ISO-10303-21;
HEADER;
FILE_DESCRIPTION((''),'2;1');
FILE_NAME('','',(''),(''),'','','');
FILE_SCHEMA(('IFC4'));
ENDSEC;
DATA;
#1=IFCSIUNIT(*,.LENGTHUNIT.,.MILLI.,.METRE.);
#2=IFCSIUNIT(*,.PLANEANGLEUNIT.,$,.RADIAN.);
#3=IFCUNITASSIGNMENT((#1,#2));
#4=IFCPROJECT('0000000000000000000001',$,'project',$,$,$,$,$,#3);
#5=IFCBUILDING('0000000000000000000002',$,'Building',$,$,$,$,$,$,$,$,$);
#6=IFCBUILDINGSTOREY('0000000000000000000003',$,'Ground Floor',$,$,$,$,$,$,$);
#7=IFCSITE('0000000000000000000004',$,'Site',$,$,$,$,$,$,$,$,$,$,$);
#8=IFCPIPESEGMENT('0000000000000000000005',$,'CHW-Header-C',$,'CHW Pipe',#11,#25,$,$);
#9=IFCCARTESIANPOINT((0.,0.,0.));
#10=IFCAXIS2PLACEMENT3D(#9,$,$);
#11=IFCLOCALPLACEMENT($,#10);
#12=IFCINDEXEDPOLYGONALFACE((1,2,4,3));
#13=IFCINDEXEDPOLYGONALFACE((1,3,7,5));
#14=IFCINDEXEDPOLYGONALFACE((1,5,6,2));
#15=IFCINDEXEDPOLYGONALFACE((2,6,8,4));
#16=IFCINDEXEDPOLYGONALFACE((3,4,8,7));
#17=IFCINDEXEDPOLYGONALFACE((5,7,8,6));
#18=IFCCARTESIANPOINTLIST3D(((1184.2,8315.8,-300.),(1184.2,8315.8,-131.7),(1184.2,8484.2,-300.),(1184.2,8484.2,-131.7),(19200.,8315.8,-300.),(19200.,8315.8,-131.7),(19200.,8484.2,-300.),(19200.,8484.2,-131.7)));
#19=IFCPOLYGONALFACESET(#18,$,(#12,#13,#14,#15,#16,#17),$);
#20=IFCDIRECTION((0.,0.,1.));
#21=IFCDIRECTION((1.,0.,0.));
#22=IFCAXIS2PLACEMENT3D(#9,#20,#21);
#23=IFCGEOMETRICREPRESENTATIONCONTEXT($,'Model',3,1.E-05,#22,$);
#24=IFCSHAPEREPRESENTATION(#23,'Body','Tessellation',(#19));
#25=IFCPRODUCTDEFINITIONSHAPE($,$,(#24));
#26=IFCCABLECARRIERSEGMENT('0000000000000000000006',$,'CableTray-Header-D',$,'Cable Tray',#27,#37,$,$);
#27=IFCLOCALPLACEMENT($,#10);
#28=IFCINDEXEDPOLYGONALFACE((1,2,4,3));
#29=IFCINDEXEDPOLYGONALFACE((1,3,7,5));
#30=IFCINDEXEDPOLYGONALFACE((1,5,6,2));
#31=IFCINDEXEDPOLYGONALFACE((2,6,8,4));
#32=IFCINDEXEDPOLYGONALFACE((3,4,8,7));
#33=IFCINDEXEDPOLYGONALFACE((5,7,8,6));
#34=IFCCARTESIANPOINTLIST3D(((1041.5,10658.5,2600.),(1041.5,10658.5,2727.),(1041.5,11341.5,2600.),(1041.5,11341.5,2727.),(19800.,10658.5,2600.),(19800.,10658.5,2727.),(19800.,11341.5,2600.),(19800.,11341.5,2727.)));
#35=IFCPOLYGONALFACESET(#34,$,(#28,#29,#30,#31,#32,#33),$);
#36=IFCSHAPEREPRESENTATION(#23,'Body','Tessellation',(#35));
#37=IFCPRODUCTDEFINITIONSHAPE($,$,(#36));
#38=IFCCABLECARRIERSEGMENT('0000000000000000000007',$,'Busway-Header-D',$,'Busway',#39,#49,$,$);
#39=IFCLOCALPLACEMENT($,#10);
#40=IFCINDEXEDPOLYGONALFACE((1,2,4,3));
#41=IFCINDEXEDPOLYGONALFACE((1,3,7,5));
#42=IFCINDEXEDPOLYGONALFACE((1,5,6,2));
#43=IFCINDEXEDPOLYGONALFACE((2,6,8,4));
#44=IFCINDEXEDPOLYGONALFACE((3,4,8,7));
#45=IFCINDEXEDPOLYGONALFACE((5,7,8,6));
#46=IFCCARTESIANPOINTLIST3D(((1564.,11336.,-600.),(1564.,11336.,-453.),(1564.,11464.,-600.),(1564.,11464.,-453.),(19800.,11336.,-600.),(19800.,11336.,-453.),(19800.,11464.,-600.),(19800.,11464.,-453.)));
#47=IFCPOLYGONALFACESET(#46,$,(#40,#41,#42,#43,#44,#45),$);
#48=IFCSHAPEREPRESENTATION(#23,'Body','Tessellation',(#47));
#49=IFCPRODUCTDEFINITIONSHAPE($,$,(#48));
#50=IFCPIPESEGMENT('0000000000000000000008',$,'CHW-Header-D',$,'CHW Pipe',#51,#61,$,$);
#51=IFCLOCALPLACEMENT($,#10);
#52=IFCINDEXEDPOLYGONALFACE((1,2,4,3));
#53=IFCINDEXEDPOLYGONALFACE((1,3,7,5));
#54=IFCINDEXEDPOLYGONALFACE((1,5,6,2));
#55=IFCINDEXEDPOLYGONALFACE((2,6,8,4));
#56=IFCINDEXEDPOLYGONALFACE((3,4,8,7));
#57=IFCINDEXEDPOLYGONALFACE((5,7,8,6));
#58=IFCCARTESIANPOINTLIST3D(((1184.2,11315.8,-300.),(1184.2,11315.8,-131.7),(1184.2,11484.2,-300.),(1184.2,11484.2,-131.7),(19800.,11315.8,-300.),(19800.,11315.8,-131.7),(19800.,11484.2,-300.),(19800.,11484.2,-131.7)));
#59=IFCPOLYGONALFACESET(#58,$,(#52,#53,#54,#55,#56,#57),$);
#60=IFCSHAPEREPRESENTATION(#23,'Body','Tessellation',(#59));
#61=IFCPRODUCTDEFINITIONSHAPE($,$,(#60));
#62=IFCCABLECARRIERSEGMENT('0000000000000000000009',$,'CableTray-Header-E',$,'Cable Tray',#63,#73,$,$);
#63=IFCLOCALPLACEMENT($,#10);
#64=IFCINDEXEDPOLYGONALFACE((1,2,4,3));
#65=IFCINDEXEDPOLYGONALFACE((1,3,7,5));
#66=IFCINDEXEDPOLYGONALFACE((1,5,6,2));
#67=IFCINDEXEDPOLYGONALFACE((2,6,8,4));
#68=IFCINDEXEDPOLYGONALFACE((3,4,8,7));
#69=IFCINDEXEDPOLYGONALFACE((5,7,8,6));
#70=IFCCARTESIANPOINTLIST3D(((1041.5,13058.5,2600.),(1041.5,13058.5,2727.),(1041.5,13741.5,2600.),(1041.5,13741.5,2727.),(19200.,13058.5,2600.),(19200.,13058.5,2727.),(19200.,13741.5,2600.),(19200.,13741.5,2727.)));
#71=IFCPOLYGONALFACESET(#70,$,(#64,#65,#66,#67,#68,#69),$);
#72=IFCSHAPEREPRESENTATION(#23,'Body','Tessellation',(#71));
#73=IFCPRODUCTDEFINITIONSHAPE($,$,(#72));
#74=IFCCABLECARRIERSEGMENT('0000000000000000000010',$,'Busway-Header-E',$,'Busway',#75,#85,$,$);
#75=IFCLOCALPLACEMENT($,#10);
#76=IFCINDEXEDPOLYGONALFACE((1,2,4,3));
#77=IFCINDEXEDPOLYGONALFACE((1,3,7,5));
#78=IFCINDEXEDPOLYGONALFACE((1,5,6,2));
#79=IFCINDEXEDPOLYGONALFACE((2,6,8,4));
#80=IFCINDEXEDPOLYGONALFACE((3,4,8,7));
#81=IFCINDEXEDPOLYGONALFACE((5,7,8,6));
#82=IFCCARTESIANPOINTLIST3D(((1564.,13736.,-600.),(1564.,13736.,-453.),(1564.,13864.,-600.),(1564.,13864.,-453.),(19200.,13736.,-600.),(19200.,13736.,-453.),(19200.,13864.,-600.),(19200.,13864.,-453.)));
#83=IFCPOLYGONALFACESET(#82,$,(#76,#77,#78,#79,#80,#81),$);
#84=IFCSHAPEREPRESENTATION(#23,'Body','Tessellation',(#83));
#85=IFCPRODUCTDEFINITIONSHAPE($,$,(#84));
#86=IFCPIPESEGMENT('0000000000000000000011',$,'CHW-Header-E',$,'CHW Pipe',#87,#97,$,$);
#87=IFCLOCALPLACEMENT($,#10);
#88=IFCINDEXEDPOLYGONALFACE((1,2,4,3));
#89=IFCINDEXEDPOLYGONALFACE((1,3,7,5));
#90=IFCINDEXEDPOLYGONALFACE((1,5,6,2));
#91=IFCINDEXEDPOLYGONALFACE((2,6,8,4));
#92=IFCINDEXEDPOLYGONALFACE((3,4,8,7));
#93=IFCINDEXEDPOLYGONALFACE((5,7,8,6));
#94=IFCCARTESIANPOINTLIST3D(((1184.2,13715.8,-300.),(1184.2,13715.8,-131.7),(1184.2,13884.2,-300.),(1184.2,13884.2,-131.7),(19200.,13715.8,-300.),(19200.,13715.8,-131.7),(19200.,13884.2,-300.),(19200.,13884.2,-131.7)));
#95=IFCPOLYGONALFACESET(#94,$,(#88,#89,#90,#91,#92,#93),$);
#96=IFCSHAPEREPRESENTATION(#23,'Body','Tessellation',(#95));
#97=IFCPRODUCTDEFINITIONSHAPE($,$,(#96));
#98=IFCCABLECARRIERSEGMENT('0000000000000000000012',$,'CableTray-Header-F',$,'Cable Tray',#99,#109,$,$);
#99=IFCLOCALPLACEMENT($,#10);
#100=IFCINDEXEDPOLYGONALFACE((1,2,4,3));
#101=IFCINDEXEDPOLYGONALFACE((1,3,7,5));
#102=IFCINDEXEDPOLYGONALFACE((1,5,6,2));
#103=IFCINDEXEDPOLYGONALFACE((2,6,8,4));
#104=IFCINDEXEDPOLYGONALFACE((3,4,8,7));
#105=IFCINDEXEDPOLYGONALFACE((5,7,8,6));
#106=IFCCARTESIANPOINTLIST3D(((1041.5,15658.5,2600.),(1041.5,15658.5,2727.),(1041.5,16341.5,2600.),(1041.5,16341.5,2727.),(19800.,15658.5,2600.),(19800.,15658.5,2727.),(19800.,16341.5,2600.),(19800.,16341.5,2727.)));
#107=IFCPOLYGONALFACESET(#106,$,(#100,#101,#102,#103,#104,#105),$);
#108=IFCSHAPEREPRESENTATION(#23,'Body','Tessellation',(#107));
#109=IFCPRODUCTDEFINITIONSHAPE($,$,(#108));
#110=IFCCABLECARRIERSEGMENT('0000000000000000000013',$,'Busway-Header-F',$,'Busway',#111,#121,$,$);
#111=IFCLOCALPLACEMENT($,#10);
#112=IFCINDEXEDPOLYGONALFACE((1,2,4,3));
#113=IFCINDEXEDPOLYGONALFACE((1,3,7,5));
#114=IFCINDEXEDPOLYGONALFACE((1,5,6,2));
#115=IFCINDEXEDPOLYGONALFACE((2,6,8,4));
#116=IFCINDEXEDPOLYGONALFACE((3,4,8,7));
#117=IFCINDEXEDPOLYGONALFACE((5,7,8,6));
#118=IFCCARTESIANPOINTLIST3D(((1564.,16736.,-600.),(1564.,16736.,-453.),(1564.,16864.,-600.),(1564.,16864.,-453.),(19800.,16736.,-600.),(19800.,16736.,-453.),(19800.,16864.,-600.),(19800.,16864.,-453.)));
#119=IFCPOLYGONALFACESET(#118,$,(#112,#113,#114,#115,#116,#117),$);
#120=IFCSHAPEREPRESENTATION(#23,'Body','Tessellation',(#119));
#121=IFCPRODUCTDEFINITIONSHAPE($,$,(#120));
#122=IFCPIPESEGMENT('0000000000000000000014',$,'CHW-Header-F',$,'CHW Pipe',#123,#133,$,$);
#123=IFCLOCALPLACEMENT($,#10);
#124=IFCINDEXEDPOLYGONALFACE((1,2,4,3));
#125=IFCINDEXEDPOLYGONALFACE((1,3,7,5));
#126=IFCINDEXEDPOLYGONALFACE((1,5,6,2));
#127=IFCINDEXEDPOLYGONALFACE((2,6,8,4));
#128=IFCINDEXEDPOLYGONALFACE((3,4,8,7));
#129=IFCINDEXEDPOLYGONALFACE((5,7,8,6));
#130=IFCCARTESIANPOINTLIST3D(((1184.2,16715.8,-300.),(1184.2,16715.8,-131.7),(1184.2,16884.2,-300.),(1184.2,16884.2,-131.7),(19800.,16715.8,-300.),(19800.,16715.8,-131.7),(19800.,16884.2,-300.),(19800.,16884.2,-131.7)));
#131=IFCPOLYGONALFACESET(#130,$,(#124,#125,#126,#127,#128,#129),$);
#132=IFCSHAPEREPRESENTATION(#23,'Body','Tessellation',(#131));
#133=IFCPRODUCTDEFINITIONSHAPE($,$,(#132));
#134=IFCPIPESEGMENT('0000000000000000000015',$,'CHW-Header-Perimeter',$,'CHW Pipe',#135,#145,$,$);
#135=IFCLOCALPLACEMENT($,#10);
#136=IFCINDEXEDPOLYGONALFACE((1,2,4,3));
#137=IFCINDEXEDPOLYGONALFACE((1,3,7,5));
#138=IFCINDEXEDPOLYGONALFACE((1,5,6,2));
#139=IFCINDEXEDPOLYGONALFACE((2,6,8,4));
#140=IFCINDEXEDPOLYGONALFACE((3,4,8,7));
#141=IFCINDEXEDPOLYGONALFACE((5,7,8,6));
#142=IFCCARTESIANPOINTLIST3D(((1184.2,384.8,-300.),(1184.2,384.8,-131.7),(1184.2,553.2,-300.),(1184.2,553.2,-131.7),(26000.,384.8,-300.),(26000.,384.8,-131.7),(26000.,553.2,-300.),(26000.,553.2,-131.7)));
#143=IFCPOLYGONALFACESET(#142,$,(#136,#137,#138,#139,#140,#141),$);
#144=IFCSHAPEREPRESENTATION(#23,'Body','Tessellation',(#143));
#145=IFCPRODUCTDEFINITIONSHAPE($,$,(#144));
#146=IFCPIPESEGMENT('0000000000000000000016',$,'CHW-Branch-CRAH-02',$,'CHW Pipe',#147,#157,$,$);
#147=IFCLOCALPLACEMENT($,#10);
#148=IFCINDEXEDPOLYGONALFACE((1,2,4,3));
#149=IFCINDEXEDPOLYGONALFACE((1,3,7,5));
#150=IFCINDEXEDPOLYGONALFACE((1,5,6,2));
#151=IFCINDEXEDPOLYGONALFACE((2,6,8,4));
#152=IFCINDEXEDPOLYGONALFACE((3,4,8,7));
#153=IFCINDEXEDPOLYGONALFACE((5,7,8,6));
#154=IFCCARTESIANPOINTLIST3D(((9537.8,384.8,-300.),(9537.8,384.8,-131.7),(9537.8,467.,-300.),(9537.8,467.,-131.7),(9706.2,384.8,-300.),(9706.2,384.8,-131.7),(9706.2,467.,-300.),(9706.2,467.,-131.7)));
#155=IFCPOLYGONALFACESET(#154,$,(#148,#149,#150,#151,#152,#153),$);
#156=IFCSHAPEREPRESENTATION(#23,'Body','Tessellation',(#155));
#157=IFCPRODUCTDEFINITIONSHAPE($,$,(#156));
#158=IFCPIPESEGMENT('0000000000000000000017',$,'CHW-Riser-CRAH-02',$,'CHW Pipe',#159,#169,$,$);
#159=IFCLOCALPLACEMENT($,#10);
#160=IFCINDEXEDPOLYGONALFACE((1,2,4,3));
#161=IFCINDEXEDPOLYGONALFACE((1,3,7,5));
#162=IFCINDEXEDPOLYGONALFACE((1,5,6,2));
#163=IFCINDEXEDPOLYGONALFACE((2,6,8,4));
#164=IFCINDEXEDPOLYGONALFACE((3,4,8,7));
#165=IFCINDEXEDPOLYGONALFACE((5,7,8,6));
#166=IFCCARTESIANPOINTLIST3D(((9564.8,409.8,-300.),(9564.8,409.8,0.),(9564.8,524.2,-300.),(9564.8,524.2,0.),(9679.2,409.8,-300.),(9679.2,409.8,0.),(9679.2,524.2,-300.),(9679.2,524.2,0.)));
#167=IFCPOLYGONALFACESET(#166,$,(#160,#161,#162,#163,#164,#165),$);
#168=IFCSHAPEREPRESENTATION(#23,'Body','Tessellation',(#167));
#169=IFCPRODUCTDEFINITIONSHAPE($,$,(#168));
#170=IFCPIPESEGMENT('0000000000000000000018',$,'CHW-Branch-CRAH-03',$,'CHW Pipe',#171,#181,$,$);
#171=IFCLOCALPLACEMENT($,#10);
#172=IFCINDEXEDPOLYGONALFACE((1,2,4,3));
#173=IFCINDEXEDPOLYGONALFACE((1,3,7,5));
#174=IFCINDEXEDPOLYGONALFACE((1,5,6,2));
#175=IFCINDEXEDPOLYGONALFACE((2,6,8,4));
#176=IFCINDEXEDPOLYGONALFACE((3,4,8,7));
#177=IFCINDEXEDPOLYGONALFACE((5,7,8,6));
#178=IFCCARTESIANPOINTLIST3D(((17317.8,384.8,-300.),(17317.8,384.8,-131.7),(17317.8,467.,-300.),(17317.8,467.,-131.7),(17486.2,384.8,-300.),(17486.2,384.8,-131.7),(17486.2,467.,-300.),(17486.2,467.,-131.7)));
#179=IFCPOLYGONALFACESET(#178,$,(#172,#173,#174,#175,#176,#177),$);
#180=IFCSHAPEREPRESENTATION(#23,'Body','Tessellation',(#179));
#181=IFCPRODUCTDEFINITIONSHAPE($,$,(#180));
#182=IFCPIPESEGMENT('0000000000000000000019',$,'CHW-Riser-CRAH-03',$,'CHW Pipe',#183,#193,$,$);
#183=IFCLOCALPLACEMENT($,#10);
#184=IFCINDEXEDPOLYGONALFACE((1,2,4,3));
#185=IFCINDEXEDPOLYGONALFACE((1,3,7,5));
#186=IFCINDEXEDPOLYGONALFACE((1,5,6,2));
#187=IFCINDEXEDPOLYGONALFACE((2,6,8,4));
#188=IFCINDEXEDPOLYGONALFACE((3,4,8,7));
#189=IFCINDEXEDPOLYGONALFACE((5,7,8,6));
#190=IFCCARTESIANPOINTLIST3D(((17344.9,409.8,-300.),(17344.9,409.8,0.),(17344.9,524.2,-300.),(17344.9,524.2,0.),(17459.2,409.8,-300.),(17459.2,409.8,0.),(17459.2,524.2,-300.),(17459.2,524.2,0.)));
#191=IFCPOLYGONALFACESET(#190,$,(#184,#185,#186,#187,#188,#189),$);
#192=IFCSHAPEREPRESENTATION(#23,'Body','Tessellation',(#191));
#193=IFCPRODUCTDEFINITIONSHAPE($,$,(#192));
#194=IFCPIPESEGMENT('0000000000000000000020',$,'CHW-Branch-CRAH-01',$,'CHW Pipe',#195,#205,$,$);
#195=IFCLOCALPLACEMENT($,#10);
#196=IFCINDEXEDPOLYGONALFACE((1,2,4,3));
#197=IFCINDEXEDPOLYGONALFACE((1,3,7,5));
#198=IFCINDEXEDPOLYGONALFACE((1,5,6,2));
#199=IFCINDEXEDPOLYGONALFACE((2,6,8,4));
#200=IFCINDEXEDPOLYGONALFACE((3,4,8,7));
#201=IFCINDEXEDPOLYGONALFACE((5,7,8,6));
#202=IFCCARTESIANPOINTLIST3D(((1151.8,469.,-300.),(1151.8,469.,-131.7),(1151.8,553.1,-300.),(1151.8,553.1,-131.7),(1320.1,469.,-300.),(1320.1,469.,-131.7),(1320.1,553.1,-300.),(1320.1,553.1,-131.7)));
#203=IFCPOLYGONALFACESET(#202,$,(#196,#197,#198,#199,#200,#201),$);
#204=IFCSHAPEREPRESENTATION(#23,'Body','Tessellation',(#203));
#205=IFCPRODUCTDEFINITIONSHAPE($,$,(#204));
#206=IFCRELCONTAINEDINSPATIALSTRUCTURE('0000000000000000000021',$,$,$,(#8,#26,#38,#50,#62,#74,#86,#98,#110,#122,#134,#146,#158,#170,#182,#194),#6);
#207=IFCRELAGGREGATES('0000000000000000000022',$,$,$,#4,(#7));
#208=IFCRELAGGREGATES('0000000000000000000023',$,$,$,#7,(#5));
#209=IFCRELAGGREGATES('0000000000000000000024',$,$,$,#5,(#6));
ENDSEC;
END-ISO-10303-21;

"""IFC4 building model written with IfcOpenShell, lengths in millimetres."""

from ifc_helpers import new_model, si_unit, frame, origin_with_axes, place, context, project, spatial, rectangle, extrude, element, save


model = new_model("IFC4")

# Units and contexts
model_context = context("Model", 3, precision=1e-05, world=origin_with_axes())
ifc_project = project(units=[si_unit("LENGTHUNIT", "METRE", prefix="MILLI"), si_unit("PLANEANGLEUNIT", "RADIAN")])

# Site, building, storey
site = spatial("IfcSite", under=ifc_project, Name="Site")
building = spatial("IfcBuilding", under=site, Name="Building")
storey = spatial("IfcBuildingStorey", under=building, Name="Ground Floor")

# Pipe segment
pipe_segment_1_placement = place(None, origin_with_axes())
element("IfcPipeSegment", 1, at=pipe_segment_1_placement, inside=storey, Name="CHW-Header-C", ObjectType="CHW Pipe", context=model_context, shape_type="SweptSolid", body=[
    extrude(rectangle(XDim=18015.8, YDim=168.3), frame((10192.1, 8400.0, -300.0), z_axis=(0.0, 0.0, 1.0), x_axis=(1.0, 0.0, 0.0)), (0.0, 0.0, 1.0), 168.3),
])

# Cable carrier segments
cable_carrier_segment_1_placement = place(None, origin_with_axes())
element("IfcCableCarrierSegment", 2, at=cable_carrier_segment_1_placement, inside=storey, Name="CableTray-Header-D", ObjectType="Cable Tray", context=model_context, shape_type="SweptSolid", body=[
    extrude(rectangle(XDim=18758.5, YDim=683.0), frame((10420.8, 11000.0, 2600.0), z_axis=(0.0, 0.0, 1.0), x_axis=(1.0, 0.0, 0.0)), (0.0, 0.0, 1.0), 127.0),
])
cable_carrier_segment_2_placement = place(None, origin_with_axes())
element("IfcCableCarrierSegment", 3, at=cable_carrier_segment_2_placement, inside=storey, Name="Busway-Header-D", ObjectType="Busway", context=model_context, shape_type="SweptSolid", body=[
    extrude(rectangle(XDim=18236.0, YDim=128.0), frame((10682.0, 11400.0, -600.0), z_axis=(0.0, 0.0, 1.0), x_axis=(1.0, 0.0, 0.0)), (0.0, 0.0, 1.0), 147.0),
])

# Pipe segment
pipe_segment_2_placement = place(None, origin_with_axes())
element("IfcPipeSegment", 4, at=pipe_segment_2_placement, inside=storey, Name="CHW-Header-D", ObjectType="CHW Pipe", context=model_context, shape_type="SweptSolid", body=[
    extrude(rectangle(XDim=18615.8, YDim=168.3), frame((10492.1, 11400.0, -300.0), z_axis=(0.0, 0.0, 1.0), x_axis=(1.0, 0.0, 0.0)), (0.0, 0.0, 1.0), 168.3),
])

# Cable carrier segments
cable_carrier_segment_3_placement = place(None, origin_with_axes())
element("IfcCableCarrierSegment", 5, at=cable_carrier_segment_3_placement, inside=storey, Name="CableTray-Header-E", ObjectType="Cable Tray", context=model_context, shape_type="SweptSolid", body=[
    extrude(rectangle(XDim=18158.5, YDim=683.0), frame((10120.8, 13400.0, 2600.0), z_axis=(0.0, 0.0, 1.0), x_axis=(1.0, 0.0, 0.0)), (0.0, 0.0, 1.0), 127.0),
])
cable_carrier_segment_4_placement = place(None, origin_with_axes())
element("IfcCableCarrierSegment", 6, at=cable_carrier_segment_4_placement, inside=storey, Name="Busway-Header-E", ObjectType="Busway", context=model_context, shape_type="SweptSolid", body=[
    extrude(rectangle(XDim=17636.0, YDim=128.0), frame((10382.0, 13800.0, -600.0), z_axis=(0.0, 0.0, 1.0), x_axis=(1.0, 0.0, 0.0)), (0.0, 0.0, 1.0), 147.0),
])

# Pipe segment
pipe_segment_3_placement = place(None, origin_with_axes())
element("IfcPipeSegment", 7, at=pipe_segment_3_placement, inside=storey, Name="CHW-Header-E", ObjectType="CHW Pipe", context=model_context, shape_type="SweptSolid", body=[
    extrude(rectangle(XDim=18015.8, YDim=168.3), frame((10192.1, 13800.0, -300.0), z_axis=(0.0, 0.0, 1.0), x_axis=(1.0, 0.0, 0.0)), (0.0, 0.0, 1.0), 168.3),
])

# Cable carrier segments
cable_carrier_segment_5_placement = place(None, origin_with_axes())
element("IfcCableCarrierSegment", 8, at=cable_carrier_segment_5_placement, inside=storey, Name="CableTray-Header-F", ObjectType="Cable Tray", context=model_context, shape_type="SweptSolid", body=[
    extrude(rectangle(XDim=18758.5, YDim=683.0), frame((10420.8, 16000.0, 2600.0), z_axis=(0.0, 0.0, 1.0), x_axis=(1.0, 0.0, 0.0)), (0.0, 0.0, 1.0), 127.0),
])
cable_carrier_segment_6_placement = place(None, origin_with_axes())
element("IfcCableCarrierSegment", 9, at=cable_carrier_segment_6_placement, inside=storey, Name="Busway-Header-F", ObjectType="Busway", context=model_context, shape_type="SweptSolid", body=[
    extrude(rectangle(XDim=18236.0, YDim=128.0), frame((10682.0, 16800.0, -600.0), z_axis=(0.0, 0.0, 1.0), x_axis=(1.0, 0.0, 0.0)), (0.0, 0.0, 1.0), 147.0),
])

# Pipe segments
pipe_segment_4_placement = place(None, origin_with_axes())
element("IfcPipeSegment", 10, at=pipe_segment_4_placement, inside=storey, Name="CHW-Header-F", ObjectType="CHW Pipe", context=model_context, shape_type="SweptSolid", body=[
    extrude(rectangle(XDim=18615.8, YDim=168.3), frame((10492.1, 16800.0, -300.0), z_axis=(0.0, 0.0, 1.0), x_axis=(1.0, 0.0, 0.0)), (0.0, 0.0, 1.0), 168.3),
])
pipe_segment_5_placement = place(None, origin_with_axes())
element("IfcPipeSegment", 11, at=pipe_segment_5_placement, inside=storey, Name="CHW-Header-Perimeter", ObjectType="CHW Pipe", context=model_context, shape_type="SweptSolid", body=[
    extrude(rectangle(XDim=24815.8, YDim=168.3), frame((13592.1, 469.0, -300.0), z_axis=(0.0, 0.0, 1.0), x_axis=(1.0, 0.0, 0.0)), (0.0, 0.0, 1.0), 168.3),
])
pipe_segment_6_placement = place(None, origin_with_axes())
element("IfcPipeSegment", 12, at=pipe_segment_6_placement, inside=storey, Name="CHW-Branch-CRAH-02", ObjectType="CHW Pipe", context=model_context, shape_type="SweptSolid", body=[
    extrude(rectangle(XDim=168.3, YDim=82.1), frame((9622.0, 425.9, -300.0), z_axis=(0.0, 0.0, 1.0), x_axis=(1.0, 0.0, 0.0)), (0.0, 0.0, 1.0), 168.3),
])
pipe_segment_7_placement = place(None, origin_with_axes())
element("IfcPipeSegment", 13, at=pipe_segment_7_placement, inside=storey, Name="CHW-Riser-CRAH-02", ObjectType="CHW Pipe", context=model_context, shape_type="SweptSolid", body=[
    extrude(rectangle(XDim=114.3, YDim=114.3), frame((9622.0, 467.0, -300.0), z_axis=(0.0, 0.0, 1.0), x_axis=(1.0, 0.0, 0.0)), (0.0, 0.0, 1.0), 300.0),
])
pipe_segment_8_placement = place(None, origin_with_axes())
element("IfcPipeSegment", 14, at=pipe_segment_8_placement, inside=storey, Name="CHW-Branch-CRAH-03", ObjectType="CHW Pipe", context=model_context, shape_type="SweptSolid", body=[
    extrude(rectangle(XDim=168.3, YDim=82.1), frame((17402.0, 425.9, -300.0), z_axis=(0.0, 0.0, 1.0), x_axis=(1.0, 0.0, 0.0)), (0.0, 0.0, 1.0), 168.3),
])
pipe_segment_9_placement = place(None, origin_with_axes())
element("IfcPipeSegment", 15, at=pipe_segment_9_placement, inside=storey, Name="CHW-Riser-CRAH-03", ObjectType="CHW Pipe", context=model_context, shape_type="SweptSolid", body=[
    extrude(rectangle(XDim=114.3, YDim=114.3), frame((17402.0, 467.0, -300.0), z_axis=(0.0, 0.0, 1.0), x_axis=(1.0, 0.0, 0.0)), (0.0, 0.0, 1.0), 300.0),
])
pipe_segment_10_placement = place(None, origin_with_axes())
element("IfcPipeSegment", 16, at=pipe_segment_10_placement, inside=storey, Name="CHW-Branch-CRAH-01", ObjectType="CHW Pipe", context=model_context, shape_type="SweptSolid", body=[
    extrude(rectangle(XDim=168.3, YDim=84.1), frame((1236.0, 511.1, -300.0), z_axis=(0.0, 0.0, 1.0), x_axis=(1.0, 0.0, 0.0)), (0.0, 0.0, 1.0), 168.3),
])

save(model, "model.ifc")
